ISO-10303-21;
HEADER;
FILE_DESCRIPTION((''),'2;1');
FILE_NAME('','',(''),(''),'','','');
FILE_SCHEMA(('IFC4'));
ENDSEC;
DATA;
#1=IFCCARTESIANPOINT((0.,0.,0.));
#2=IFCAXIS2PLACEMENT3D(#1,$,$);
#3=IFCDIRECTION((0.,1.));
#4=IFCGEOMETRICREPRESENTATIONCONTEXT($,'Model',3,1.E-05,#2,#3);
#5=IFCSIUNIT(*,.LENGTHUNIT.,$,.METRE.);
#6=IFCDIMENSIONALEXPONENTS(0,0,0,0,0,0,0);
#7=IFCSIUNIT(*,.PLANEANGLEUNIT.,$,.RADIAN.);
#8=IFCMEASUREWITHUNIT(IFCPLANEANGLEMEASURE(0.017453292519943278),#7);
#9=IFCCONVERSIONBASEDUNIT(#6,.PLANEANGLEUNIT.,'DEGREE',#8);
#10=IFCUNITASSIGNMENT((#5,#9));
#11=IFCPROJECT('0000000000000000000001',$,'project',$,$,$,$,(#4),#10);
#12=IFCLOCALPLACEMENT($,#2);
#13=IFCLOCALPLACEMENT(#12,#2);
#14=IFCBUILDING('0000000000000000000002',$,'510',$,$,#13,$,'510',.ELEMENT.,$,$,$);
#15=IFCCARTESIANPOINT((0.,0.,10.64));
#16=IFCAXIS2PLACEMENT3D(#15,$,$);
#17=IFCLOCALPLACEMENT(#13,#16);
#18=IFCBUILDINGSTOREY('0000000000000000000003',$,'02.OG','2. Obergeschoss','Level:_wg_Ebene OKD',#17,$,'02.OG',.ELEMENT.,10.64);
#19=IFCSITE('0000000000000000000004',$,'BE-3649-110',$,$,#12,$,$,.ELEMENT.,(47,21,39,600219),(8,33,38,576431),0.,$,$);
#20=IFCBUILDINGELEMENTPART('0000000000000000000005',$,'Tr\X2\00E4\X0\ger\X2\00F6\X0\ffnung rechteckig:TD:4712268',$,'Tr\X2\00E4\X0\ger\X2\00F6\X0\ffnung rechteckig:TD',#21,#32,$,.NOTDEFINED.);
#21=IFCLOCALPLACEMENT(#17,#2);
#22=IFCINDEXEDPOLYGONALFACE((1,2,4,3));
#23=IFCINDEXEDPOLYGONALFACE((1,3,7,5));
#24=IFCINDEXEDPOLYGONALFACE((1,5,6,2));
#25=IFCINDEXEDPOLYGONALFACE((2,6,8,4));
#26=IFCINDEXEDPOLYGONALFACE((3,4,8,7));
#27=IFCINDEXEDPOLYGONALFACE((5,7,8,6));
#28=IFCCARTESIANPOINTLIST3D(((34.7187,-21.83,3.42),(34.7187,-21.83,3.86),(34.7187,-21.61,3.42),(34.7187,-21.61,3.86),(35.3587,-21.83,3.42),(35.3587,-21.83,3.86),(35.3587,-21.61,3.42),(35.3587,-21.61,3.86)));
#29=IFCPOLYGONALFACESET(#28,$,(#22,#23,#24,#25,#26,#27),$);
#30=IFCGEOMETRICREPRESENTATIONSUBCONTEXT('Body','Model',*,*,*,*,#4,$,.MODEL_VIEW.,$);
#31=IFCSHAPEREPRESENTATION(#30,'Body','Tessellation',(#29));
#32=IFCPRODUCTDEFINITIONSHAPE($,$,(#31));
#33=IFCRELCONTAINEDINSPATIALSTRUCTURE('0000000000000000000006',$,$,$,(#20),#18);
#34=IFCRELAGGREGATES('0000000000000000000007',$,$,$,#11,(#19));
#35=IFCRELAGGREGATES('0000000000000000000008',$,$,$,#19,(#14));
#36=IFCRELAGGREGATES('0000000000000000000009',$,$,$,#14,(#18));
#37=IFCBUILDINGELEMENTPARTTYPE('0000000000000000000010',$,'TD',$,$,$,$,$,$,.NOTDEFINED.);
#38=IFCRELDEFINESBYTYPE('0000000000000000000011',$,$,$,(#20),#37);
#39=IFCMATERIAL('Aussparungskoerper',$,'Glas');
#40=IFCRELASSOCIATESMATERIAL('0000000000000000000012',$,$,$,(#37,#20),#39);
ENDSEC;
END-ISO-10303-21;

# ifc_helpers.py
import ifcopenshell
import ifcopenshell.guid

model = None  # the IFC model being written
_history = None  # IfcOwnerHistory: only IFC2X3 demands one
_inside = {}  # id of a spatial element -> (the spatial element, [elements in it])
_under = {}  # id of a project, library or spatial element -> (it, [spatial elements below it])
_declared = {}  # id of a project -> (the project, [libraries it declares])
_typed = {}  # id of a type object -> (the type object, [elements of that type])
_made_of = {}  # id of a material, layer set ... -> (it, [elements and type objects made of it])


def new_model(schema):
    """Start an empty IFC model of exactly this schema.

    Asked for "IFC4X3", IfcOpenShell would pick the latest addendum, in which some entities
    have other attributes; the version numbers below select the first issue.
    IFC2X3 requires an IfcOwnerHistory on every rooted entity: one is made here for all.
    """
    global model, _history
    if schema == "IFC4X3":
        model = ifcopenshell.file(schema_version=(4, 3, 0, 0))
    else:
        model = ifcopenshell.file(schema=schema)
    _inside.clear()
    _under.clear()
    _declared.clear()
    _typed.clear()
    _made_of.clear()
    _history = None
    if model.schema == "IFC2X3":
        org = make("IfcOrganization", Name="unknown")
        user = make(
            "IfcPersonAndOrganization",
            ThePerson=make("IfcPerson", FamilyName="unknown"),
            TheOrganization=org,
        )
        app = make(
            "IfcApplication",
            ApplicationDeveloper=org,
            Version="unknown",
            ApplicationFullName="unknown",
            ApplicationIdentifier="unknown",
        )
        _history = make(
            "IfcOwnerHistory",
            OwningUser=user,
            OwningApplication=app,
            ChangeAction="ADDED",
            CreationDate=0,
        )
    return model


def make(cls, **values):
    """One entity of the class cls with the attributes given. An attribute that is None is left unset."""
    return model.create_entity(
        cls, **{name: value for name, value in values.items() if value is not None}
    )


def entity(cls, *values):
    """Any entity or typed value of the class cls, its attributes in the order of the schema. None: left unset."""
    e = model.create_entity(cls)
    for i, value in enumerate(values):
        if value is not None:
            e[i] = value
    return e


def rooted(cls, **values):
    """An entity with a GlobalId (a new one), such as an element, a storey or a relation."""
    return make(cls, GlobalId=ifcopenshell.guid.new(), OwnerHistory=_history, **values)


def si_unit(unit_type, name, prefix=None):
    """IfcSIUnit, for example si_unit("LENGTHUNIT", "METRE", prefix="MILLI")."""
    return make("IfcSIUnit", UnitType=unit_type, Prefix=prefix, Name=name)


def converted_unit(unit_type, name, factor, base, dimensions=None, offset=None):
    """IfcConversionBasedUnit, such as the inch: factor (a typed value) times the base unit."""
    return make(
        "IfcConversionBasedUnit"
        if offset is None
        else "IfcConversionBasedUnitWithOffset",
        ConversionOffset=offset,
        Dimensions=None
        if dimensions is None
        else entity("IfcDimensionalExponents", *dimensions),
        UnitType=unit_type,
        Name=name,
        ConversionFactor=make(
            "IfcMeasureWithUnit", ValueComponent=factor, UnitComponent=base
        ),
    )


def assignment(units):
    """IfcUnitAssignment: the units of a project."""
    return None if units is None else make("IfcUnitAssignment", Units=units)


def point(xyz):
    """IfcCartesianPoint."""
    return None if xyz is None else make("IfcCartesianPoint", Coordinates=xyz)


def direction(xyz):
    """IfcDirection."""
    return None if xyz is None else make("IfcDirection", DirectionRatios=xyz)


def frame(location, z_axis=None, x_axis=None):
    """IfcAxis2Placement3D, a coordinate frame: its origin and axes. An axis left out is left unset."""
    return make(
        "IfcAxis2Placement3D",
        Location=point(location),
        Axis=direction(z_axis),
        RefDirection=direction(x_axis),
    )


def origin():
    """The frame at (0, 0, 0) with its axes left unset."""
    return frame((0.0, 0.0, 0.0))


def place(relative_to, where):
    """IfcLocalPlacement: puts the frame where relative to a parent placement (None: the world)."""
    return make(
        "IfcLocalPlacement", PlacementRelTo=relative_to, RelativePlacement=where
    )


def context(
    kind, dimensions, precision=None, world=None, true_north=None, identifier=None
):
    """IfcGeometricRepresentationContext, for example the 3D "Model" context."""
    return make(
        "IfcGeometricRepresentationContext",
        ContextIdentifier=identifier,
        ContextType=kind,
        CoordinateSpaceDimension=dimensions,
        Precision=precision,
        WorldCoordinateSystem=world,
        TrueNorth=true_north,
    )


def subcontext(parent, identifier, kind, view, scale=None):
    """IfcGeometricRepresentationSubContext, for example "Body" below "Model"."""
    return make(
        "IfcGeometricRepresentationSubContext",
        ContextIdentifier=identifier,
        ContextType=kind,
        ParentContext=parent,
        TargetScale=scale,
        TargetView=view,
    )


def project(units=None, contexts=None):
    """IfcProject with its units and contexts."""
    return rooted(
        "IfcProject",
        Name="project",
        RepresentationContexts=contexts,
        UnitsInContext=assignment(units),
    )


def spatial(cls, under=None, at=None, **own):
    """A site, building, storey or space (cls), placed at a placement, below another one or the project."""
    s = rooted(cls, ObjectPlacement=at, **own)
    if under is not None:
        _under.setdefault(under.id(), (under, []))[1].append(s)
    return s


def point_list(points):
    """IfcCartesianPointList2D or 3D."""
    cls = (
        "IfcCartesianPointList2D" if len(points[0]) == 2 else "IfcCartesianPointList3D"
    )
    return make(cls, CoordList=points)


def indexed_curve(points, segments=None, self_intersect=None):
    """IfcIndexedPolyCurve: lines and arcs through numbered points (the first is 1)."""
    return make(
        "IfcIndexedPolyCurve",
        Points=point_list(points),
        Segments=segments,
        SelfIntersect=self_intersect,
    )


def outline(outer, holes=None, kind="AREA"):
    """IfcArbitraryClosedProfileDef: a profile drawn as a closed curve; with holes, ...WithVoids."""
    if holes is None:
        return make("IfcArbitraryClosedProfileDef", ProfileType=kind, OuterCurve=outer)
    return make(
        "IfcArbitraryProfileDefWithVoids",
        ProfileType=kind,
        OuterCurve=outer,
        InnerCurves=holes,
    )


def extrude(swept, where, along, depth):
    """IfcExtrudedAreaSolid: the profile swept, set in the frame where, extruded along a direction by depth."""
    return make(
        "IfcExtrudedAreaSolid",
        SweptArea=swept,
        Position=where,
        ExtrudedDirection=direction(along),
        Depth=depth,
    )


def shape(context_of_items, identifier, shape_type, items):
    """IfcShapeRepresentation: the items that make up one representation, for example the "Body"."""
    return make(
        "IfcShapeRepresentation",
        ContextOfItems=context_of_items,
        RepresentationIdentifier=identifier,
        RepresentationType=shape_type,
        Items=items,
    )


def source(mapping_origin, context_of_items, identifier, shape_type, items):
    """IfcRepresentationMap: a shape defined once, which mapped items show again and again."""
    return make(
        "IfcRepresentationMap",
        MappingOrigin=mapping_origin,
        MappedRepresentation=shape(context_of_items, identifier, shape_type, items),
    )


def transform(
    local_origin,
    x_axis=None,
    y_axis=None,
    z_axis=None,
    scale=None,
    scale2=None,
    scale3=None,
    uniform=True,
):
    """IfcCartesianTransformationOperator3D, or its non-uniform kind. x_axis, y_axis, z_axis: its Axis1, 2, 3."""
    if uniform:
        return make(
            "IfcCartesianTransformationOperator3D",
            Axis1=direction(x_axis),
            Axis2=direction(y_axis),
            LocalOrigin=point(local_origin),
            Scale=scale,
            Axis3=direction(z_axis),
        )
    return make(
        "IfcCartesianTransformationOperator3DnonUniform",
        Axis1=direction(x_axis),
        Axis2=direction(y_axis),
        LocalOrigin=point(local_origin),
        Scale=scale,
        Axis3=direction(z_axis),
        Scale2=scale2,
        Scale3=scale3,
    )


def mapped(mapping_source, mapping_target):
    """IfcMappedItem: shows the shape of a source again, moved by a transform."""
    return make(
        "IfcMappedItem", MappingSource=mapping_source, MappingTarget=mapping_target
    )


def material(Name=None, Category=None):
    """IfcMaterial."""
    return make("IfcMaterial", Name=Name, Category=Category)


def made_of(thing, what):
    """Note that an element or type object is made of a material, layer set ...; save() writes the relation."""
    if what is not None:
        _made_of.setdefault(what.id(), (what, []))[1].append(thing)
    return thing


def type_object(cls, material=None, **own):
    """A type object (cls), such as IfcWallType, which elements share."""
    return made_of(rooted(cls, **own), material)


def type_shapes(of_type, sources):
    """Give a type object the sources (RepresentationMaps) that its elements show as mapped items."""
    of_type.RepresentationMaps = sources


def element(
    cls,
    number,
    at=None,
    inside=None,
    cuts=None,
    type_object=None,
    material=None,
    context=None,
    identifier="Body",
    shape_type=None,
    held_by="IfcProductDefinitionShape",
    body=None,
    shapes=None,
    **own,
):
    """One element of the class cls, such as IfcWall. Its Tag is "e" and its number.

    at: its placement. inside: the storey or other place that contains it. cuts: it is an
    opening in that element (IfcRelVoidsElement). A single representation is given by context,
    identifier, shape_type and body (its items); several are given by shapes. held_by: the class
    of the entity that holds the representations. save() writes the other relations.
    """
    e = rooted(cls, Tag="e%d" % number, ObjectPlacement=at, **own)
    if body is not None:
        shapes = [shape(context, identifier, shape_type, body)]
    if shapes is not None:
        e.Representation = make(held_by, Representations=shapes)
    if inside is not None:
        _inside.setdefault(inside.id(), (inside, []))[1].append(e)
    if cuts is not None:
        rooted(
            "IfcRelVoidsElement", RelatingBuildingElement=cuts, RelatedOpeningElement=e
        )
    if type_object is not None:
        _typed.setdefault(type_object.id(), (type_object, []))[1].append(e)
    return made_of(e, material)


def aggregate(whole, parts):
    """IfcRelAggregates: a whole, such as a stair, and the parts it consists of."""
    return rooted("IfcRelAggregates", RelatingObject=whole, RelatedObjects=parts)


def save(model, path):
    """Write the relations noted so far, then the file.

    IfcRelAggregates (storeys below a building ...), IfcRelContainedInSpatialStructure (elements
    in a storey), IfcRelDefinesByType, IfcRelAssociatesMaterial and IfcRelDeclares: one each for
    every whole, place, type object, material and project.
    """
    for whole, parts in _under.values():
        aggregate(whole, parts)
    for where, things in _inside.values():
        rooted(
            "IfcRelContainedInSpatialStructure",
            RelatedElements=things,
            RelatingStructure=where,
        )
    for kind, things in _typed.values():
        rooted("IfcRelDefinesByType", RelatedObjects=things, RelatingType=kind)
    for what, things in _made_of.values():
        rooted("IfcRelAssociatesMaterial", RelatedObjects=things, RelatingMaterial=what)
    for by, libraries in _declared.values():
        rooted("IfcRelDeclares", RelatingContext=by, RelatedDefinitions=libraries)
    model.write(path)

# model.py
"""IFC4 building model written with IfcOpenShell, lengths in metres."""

from ifc_helpers import new_model, entity, si_unit, converted_unit, direction, frame, origin, place, context, subcontext, project, spatial, indexed_curve, outline, extrude, source, transform, mapped, material, type_object, type_shapes, element, save


model = new_model("IFC4")

# Units and contexts
model_context = context("Model", 3, precision=1e-05, world=origin(), true_north=direction((0.0, 1.0)))
body_context = subcontext(model_context, "Body", "Model", "MODEL_VIEW")
ifc_project = project(units=[si_unit("LENGTHUNIT", "METRE"), converted_unit("PLANEANGLEUNIT", "DEGREE", entity("IfcPlaneAngleMeasure", 0.017453292519943278), si_unit("PLANEANGLEUNIT", "RADIAN"), dimensions=[0, 0, 0, 0, 0, 0, 0])], contexts=[model_context])

# Site, building, storey
site_placement = place(None, origin())
site = spatial("IfcSite", under=ifc_project, at=site_placement, Name="BE-3649-110", CompositionType="ELEMENT", RefLatitude=(47, 21, 39, 600219), RefLongitude=(8, 33, 38, 576431), RefElevation=0.0)
building_placement = place(site_placement, origin())
building = spatial("IfcBuilding", under=site, at=building_placement, Name="510", LongName="510", CompositionType="ELEMENT")
storey_placement = place(building_placement, frame((0.0, 0.0, 10.64)))
storey = spatial("IfcBuildingStorey", under=building, at=storey_placement, Name="02.OG", Description="2. Obergeschoss", ObjectType="Level:_wg_Ebene OKD", LongName="02.OG", CompositionType="ELEMENT", Elevation=10.64)

# Building element part
ifc_material_1 = material(Name="Aussparungskoerper", Category="Glas")
building_element_part_type_1 = type_object("IfcBuildingElementPartType", Name="TD", PredefinedType="NOTDEFINED", material=ifc_material_1)
shared_shape_1 = source(origin(), body_context, "Body", "SweptSolid", [
    extrude(outline(indexed_curve([(-0.11, -0.32), (0.11, -0.32), (0.11, 0.32), (-0.11, 0.32), (-0.11, -0.32)], self_intersect=False)), frame((35.0387, -21.72, -0.44), z_axis=(0.0, 0.0, 1.0), x_axis=(0.0, 1.0, 0.0)), (0.0, 0.0, 1.0), 0.44),
])
type_shapes(building_element_part_type_1, [shared_shape_1])
building_element_part_1_placement = place(storey_placement, frame((0.0, 0.0, 3.86)))
element("IfcBuildingElementPart", 1, at=building_element_part_1_placement, inside=storey, type_object=building_element_part_type_1, material=ifc_material_1, Name="Trägeröffnung rechteckig:TD:4712268", ObjectType="Trägeröffnung rechteckig:TD", PredefinedType="NOTDEFINED", context=body_context, shape_type="MappedRepresentation", body=[
    mapped(shared_shape_1, transform((0.0, 0.0, 0.0), scale=1.0)),
])

save(model, "model.ifc")
